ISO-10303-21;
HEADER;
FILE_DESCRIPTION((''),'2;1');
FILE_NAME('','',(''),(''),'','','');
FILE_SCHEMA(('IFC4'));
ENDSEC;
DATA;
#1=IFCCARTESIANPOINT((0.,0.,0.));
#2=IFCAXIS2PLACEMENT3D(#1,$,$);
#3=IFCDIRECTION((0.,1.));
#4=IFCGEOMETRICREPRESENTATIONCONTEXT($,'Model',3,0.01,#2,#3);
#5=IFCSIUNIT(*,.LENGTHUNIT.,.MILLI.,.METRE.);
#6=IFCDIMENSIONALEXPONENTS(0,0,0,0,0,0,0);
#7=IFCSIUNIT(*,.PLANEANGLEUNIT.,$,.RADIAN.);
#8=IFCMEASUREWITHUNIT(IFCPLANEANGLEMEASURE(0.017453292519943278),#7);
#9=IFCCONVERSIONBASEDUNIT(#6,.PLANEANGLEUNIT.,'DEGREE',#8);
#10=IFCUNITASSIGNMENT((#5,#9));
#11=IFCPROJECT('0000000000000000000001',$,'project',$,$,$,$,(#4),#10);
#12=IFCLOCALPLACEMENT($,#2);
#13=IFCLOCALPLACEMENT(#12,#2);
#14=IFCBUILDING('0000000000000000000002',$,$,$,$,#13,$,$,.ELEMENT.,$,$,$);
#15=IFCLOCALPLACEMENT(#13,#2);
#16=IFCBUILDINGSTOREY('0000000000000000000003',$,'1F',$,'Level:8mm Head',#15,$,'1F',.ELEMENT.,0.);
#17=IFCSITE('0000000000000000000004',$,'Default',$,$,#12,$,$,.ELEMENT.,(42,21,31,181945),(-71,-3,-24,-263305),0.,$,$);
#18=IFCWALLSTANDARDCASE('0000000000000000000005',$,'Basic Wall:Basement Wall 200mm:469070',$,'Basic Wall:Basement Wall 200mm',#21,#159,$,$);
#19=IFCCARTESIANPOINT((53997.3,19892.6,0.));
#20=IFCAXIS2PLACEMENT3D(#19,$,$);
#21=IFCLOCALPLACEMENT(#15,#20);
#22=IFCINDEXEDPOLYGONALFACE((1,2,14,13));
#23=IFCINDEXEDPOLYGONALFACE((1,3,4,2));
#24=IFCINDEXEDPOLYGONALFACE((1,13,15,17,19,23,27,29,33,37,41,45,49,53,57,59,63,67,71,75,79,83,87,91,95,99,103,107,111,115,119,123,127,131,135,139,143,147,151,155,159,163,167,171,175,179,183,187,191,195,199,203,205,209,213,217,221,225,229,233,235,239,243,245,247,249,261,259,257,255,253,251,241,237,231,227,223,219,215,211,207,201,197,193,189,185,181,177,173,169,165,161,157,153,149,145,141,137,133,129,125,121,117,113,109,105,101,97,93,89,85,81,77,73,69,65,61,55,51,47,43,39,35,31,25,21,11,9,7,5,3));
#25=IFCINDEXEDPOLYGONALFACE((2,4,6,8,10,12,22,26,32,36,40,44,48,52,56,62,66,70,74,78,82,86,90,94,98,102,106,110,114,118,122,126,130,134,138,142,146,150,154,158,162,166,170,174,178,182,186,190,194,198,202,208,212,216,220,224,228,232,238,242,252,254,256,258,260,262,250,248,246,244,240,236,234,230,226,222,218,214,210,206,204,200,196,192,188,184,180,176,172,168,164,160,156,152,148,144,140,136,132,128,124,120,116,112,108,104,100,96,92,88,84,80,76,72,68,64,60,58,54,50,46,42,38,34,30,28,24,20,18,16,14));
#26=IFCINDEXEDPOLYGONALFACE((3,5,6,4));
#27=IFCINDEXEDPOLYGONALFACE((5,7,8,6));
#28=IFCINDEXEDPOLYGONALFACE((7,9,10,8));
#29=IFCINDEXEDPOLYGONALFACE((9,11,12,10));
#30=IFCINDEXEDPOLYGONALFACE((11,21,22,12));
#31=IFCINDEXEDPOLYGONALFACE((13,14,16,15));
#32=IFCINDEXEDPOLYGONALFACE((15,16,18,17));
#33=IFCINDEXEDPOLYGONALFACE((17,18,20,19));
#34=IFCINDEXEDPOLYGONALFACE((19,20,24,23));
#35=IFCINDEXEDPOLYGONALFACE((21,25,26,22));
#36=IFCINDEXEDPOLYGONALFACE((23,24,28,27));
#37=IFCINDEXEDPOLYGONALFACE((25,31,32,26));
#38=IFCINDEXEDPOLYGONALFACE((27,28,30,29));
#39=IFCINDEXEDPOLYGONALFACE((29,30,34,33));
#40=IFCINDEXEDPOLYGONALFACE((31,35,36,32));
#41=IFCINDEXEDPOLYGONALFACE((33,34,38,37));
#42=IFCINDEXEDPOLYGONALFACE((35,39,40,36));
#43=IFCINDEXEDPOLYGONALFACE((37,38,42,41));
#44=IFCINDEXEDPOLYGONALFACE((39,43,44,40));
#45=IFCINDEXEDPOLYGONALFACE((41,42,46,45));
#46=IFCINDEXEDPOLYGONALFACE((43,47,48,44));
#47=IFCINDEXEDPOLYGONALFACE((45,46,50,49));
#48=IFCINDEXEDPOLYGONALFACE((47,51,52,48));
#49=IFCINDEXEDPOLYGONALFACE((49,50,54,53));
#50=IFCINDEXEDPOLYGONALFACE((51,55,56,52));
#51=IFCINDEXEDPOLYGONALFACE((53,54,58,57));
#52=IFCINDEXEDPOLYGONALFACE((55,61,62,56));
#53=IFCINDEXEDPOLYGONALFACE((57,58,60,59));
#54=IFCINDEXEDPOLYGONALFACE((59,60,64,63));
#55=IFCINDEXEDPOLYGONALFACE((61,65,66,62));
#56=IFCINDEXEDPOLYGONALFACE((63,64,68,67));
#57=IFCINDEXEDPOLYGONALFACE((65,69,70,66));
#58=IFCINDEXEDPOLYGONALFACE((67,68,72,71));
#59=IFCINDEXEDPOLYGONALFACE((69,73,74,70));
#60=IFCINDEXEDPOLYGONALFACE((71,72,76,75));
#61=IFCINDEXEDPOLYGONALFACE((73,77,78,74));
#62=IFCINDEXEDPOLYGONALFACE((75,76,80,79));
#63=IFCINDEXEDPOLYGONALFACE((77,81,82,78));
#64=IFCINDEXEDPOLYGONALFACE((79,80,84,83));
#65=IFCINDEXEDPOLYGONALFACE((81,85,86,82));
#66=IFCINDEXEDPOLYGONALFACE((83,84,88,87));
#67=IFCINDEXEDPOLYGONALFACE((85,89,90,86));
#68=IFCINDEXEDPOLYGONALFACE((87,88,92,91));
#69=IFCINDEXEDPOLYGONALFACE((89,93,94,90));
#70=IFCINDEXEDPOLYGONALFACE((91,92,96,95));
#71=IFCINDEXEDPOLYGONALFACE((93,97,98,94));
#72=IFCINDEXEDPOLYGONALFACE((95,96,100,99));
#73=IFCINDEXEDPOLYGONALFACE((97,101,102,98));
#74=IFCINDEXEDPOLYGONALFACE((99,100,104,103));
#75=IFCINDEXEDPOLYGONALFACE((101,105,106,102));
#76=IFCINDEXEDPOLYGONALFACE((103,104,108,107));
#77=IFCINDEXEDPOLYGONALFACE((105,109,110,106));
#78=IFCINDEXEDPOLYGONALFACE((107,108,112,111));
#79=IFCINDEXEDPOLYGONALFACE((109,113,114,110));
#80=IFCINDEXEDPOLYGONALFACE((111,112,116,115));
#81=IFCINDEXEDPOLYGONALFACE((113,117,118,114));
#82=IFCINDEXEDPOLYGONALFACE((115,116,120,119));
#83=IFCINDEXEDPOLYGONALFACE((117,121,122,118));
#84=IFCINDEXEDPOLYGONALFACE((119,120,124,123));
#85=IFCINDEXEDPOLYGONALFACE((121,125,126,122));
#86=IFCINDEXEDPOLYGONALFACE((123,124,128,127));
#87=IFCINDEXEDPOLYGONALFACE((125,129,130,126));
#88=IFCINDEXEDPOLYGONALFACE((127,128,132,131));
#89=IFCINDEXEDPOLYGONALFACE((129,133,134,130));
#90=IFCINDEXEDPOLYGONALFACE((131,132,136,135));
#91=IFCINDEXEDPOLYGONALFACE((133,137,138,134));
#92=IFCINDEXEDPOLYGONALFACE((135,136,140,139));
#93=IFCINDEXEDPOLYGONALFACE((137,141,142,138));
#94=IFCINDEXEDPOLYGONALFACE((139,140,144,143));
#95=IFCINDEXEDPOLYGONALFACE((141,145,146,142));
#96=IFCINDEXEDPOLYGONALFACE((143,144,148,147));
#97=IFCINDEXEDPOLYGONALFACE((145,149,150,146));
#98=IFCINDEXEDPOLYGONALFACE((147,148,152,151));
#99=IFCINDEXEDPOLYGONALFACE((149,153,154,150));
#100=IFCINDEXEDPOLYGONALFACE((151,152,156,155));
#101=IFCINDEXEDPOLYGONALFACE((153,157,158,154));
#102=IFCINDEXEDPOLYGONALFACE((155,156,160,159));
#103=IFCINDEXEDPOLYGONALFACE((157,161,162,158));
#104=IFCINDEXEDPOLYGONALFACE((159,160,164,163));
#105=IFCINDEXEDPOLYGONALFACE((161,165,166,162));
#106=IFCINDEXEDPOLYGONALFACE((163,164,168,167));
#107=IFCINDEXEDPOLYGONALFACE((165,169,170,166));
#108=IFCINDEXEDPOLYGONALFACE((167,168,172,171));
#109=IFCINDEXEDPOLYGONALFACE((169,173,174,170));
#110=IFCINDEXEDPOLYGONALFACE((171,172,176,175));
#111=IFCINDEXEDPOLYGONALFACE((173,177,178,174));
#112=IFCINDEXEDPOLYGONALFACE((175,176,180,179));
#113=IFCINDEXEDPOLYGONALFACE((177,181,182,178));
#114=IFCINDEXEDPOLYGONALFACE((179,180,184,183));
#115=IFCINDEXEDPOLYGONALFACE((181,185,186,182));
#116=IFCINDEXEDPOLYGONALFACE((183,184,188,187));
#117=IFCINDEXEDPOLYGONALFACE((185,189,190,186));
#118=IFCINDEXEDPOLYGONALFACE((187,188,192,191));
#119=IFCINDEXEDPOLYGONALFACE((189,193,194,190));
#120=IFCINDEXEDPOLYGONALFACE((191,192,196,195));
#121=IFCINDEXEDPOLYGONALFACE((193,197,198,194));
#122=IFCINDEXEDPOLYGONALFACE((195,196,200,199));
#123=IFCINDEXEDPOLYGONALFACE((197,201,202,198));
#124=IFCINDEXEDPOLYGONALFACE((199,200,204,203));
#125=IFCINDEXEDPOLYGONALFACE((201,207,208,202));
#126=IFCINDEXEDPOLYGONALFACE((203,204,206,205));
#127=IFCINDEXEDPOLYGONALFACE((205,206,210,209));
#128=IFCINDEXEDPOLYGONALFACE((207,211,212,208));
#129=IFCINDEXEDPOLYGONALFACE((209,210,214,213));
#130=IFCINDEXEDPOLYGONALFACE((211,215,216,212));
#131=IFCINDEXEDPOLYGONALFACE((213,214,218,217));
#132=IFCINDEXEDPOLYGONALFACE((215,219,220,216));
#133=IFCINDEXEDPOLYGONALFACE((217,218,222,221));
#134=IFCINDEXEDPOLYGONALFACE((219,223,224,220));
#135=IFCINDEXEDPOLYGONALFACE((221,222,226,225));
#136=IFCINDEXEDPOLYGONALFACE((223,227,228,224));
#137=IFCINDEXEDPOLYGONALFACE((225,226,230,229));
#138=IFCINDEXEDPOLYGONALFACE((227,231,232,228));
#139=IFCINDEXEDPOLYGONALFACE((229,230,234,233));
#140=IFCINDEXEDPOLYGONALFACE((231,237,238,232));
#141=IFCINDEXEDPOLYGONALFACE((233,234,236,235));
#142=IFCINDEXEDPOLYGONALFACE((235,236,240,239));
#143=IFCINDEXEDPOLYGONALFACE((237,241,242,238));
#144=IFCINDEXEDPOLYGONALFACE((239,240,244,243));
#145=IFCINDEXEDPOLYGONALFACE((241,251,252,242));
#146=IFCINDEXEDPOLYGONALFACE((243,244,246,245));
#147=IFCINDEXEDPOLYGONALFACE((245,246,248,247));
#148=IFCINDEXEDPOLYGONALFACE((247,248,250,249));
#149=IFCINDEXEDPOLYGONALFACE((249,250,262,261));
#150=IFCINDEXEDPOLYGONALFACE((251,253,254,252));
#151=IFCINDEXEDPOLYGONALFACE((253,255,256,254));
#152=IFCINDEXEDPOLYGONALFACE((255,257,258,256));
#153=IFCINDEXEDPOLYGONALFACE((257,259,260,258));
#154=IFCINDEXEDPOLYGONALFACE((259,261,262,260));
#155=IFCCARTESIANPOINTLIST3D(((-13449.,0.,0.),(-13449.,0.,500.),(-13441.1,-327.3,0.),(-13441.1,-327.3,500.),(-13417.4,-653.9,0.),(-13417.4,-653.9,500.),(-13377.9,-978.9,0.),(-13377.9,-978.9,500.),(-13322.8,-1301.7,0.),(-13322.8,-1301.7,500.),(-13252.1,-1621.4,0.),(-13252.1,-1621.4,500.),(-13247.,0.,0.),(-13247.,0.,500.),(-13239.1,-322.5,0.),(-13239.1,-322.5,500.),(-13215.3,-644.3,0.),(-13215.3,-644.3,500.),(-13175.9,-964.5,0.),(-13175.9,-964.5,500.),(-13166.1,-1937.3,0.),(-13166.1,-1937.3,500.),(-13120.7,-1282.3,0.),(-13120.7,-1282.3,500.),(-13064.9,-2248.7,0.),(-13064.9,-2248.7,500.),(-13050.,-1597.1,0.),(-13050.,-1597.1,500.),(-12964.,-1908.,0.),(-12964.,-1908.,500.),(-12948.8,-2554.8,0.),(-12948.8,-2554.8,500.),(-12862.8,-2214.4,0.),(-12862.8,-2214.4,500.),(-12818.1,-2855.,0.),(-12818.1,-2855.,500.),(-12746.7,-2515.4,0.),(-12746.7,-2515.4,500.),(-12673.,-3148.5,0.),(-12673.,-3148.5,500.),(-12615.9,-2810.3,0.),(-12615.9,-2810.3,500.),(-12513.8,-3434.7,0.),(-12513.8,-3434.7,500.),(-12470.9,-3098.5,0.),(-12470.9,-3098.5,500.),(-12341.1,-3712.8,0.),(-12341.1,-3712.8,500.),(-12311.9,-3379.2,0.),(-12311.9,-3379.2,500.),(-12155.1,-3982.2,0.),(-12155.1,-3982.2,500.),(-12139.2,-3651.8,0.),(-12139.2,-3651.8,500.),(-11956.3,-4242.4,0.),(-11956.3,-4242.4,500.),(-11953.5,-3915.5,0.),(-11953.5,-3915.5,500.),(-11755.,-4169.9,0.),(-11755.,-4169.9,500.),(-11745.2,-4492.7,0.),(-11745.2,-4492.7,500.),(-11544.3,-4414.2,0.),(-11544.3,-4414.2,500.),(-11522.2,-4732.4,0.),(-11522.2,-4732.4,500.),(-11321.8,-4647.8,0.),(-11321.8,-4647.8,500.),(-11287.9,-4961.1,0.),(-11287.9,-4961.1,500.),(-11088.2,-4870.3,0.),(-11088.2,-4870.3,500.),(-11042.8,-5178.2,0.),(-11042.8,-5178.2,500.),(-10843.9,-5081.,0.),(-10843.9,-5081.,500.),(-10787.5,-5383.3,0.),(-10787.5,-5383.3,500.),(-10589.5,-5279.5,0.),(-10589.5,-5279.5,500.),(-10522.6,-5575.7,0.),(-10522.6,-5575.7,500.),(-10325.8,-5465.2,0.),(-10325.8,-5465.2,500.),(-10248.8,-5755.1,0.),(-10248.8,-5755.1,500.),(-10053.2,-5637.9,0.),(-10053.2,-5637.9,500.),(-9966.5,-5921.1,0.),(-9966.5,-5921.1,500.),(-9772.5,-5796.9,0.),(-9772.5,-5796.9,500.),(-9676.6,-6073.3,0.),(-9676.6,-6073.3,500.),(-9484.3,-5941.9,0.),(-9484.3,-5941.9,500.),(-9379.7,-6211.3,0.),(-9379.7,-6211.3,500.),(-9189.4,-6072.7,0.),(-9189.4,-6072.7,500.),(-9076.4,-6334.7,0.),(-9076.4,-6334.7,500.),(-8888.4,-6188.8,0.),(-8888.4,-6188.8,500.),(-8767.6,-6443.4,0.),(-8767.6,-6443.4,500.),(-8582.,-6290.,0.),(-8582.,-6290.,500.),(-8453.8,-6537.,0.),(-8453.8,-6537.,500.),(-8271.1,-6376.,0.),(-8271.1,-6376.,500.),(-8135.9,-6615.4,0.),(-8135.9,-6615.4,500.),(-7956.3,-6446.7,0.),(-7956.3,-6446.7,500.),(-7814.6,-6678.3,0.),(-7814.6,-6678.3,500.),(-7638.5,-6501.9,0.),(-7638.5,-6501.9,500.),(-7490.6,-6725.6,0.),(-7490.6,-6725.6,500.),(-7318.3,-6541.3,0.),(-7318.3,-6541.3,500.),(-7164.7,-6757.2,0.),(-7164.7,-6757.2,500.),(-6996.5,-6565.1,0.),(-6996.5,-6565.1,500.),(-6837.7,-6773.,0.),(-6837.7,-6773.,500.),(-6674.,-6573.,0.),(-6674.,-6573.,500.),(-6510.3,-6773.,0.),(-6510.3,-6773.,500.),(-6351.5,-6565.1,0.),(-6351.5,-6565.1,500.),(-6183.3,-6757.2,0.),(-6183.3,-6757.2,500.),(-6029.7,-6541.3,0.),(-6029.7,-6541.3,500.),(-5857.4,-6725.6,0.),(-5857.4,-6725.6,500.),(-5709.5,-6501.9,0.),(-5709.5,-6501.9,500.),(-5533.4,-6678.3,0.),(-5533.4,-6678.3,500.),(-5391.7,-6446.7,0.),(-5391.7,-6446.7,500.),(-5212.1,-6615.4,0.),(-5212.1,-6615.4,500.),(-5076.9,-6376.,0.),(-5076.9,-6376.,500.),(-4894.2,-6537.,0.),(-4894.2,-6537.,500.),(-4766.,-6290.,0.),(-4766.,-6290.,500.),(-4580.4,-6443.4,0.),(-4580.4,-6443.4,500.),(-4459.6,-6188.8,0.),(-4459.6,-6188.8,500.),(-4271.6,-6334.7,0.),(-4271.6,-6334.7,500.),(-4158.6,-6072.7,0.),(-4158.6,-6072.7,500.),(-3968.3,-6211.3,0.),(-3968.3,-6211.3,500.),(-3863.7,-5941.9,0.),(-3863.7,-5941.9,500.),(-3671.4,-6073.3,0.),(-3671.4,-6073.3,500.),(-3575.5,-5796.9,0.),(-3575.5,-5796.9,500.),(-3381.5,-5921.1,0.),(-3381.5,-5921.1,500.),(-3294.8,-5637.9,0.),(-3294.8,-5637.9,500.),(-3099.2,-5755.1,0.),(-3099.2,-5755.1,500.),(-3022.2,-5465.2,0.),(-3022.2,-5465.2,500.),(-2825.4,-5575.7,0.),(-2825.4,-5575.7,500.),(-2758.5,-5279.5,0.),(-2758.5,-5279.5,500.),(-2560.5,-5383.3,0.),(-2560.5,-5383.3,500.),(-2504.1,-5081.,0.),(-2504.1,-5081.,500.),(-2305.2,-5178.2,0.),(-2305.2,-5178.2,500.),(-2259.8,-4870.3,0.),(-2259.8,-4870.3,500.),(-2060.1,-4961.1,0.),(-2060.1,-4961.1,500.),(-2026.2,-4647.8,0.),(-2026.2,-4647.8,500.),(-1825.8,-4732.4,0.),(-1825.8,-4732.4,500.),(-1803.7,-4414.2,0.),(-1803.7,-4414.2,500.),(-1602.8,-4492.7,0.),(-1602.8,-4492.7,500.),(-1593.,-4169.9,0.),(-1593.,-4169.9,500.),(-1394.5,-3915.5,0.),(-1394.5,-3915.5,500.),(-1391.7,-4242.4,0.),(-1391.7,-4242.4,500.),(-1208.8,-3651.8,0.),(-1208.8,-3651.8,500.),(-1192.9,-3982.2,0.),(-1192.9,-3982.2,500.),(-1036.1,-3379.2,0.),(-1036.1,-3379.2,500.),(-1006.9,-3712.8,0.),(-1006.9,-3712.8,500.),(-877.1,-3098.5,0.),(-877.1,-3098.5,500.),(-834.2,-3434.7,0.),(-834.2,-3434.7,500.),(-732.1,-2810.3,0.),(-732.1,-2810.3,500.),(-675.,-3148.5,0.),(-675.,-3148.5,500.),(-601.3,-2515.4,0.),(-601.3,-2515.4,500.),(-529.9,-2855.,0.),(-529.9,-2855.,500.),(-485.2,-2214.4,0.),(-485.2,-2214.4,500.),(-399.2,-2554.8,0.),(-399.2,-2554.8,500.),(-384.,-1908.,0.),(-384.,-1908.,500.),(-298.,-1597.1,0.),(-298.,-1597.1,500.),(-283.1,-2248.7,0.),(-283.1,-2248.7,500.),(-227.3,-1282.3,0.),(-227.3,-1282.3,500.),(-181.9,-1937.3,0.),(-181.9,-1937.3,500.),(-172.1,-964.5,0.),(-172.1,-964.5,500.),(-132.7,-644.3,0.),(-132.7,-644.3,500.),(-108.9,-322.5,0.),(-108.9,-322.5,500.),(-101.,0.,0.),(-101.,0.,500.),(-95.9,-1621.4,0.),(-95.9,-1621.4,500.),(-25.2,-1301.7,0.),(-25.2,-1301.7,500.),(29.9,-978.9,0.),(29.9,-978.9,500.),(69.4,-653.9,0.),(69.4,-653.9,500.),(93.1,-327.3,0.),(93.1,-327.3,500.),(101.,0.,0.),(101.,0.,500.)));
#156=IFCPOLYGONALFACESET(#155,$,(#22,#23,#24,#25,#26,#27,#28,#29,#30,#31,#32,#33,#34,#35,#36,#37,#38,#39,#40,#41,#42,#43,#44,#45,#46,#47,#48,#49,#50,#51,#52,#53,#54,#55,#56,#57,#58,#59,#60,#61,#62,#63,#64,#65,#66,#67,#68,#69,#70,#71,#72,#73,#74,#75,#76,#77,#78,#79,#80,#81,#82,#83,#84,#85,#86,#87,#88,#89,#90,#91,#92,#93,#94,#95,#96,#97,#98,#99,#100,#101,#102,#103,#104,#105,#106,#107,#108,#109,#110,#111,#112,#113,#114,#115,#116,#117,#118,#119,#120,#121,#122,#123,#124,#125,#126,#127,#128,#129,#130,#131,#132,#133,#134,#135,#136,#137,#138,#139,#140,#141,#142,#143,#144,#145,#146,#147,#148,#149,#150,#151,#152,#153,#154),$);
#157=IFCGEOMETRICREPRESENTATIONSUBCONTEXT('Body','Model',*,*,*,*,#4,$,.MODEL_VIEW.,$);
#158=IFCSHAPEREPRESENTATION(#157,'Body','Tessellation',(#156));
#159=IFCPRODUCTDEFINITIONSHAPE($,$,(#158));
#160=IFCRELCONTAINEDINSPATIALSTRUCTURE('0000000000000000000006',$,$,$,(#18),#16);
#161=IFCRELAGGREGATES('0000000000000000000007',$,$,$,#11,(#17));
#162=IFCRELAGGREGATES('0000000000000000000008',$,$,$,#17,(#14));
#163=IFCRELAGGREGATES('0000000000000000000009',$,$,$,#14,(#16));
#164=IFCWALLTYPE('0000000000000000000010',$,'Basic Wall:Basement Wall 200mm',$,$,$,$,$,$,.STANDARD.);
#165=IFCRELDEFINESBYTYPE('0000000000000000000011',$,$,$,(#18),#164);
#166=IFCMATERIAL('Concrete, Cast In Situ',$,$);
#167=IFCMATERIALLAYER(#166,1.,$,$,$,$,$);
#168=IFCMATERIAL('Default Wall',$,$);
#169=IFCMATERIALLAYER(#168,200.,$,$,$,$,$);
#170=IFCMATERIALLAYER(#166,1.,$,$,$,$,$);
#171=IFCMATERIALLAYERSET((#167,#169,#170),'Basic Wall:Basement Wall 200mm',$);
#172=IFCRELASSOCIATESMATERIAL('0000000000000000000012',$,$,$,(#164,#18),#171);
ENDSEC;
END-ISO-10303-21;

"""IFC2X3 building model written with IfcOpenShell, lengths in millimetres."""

from ifc_helpers import new_model, entity, si_unit, converted_unit, direction, frame, frame_2d, origin, place, context, subcontext, project, spatial, polyline, circle_curve, parameter, trimmed, segment, composite_curve, outline, extrude, material, layer, layer_set, layer_usage, type_object, element, save


model = new_model("IFC2X3")

# Units and contexts
model_context = context("Model", 3, precision=0.01, world=origin(), true_north=direction((0.0, 1.0)))
body_context = subcontext(model_context, "Body", "Model", "MODEL_VIEW")
ifc_project = project(units=[si_unit("LENGTHUNIT", "METRE", prefix="MILLI"), converted_unit("PLANEANGLEUNIT", "DEGREE", entity("IfcPlaneAngleMeasure", 0.017453292519943278), si_unit("PLANEANGLEUNIT", "RADIAN"), dimensions=[0, 0, 0, 0, 0, 0, 0])], contexts=[model_context])

# Site, building, storey
site_placement = place(None, origin())
site = spatial("IfcSite", under=ifc_project, at=site_placement, Name="Default", CompositionType="ELEMENT", RefLatitude=(42, 21, 31, 181945), RefLongitude=(-71, -3, -24, -263305), RefElevation=0.0)
building_placement = place(site_placement, origin())
building = spatial("IfcBuilding", under=site, at=building_placement, CompositionType="ELEMENT")
storey_placement = place(building_placement, origin())
storey = spatial("IfcBuildingStorey", under=building, at=storey_placement, Name="1F", ObjectType="Level:8mm Head", LongName="1F", CompositionType="ELEMENT", Elevation=0.0)

# Shared definitions
ifc_material_1 = material(Name="Default Wall")

# Wall
ifc_material_2 = material(Name="Concrete, Cast In Situ")
ifc_layer_1 = layer(ifc_material_2, 1.0)
ifc_layer_2 = layer(ifc_material_1, 200.0)
ifc_layer_3 = layer(ifc_material_2, 1.0)
ifc_layer_set_1 = layer_set([ifc_layer_1, ifc_layer_2, ifc_layer_3], Name="Basic Wall:Basement Wall 200mm")
wall_type_1 = type_object("IfcWallType", Name="Basic Wall:Basement Wall 200mm", PredefinedType="STANDARD", material=ifc_layer_set_1)
ifc_layer_usage_1 = layer_usage(ifc_layer_set_1, "AXIS2", "POSITIVE", -101.0)
wall_1_placement = place(storey_placement, frame((53997.3, 19892.6, 0.0)))
element("IfcWallStandardCase", 1, at=wall_1_placement, inside=storey, type_object=wall_type_1, material=ifc_layer_usage_1, Name="Basic Wall:Basement Wall 200mm:469070", ObjectType="Basic Wall:Basement Wall 200mm", context=body_context, shape_type="SweptSolid", body=[
    extrude(outline(composite_curve([segment(trimmed(circle_curve(frame_2d((-6674.0, 0.0), x_axis=(1.0, 0.0)), 6775.0), [parameter(180.0)], [parameter(0.0)], True, "PARAMETER"), True, "CONTINUOUS"), segment(polyline([(101.0, 0.0), (-101.0, 0.0)]), True, "CONTINUOUS"), segment(trimmed(circle_curve(frame_2d((-6674.0, 0.0), x_axis=(1.0, 0.0)), 6573.0), [parameter(180.0)], [parameter(0.0)], True, "PARAMETER"), False, "CONTINUOUS"), segment(polyline([(-13247.0, 0.0), (-13449.0, 0.0)]), True, "CONTINUOUS")], self_intersect=False)), origin(), (0.0, 0.0, 1.0), 500.0),
])

save(model, "model.ifc")
